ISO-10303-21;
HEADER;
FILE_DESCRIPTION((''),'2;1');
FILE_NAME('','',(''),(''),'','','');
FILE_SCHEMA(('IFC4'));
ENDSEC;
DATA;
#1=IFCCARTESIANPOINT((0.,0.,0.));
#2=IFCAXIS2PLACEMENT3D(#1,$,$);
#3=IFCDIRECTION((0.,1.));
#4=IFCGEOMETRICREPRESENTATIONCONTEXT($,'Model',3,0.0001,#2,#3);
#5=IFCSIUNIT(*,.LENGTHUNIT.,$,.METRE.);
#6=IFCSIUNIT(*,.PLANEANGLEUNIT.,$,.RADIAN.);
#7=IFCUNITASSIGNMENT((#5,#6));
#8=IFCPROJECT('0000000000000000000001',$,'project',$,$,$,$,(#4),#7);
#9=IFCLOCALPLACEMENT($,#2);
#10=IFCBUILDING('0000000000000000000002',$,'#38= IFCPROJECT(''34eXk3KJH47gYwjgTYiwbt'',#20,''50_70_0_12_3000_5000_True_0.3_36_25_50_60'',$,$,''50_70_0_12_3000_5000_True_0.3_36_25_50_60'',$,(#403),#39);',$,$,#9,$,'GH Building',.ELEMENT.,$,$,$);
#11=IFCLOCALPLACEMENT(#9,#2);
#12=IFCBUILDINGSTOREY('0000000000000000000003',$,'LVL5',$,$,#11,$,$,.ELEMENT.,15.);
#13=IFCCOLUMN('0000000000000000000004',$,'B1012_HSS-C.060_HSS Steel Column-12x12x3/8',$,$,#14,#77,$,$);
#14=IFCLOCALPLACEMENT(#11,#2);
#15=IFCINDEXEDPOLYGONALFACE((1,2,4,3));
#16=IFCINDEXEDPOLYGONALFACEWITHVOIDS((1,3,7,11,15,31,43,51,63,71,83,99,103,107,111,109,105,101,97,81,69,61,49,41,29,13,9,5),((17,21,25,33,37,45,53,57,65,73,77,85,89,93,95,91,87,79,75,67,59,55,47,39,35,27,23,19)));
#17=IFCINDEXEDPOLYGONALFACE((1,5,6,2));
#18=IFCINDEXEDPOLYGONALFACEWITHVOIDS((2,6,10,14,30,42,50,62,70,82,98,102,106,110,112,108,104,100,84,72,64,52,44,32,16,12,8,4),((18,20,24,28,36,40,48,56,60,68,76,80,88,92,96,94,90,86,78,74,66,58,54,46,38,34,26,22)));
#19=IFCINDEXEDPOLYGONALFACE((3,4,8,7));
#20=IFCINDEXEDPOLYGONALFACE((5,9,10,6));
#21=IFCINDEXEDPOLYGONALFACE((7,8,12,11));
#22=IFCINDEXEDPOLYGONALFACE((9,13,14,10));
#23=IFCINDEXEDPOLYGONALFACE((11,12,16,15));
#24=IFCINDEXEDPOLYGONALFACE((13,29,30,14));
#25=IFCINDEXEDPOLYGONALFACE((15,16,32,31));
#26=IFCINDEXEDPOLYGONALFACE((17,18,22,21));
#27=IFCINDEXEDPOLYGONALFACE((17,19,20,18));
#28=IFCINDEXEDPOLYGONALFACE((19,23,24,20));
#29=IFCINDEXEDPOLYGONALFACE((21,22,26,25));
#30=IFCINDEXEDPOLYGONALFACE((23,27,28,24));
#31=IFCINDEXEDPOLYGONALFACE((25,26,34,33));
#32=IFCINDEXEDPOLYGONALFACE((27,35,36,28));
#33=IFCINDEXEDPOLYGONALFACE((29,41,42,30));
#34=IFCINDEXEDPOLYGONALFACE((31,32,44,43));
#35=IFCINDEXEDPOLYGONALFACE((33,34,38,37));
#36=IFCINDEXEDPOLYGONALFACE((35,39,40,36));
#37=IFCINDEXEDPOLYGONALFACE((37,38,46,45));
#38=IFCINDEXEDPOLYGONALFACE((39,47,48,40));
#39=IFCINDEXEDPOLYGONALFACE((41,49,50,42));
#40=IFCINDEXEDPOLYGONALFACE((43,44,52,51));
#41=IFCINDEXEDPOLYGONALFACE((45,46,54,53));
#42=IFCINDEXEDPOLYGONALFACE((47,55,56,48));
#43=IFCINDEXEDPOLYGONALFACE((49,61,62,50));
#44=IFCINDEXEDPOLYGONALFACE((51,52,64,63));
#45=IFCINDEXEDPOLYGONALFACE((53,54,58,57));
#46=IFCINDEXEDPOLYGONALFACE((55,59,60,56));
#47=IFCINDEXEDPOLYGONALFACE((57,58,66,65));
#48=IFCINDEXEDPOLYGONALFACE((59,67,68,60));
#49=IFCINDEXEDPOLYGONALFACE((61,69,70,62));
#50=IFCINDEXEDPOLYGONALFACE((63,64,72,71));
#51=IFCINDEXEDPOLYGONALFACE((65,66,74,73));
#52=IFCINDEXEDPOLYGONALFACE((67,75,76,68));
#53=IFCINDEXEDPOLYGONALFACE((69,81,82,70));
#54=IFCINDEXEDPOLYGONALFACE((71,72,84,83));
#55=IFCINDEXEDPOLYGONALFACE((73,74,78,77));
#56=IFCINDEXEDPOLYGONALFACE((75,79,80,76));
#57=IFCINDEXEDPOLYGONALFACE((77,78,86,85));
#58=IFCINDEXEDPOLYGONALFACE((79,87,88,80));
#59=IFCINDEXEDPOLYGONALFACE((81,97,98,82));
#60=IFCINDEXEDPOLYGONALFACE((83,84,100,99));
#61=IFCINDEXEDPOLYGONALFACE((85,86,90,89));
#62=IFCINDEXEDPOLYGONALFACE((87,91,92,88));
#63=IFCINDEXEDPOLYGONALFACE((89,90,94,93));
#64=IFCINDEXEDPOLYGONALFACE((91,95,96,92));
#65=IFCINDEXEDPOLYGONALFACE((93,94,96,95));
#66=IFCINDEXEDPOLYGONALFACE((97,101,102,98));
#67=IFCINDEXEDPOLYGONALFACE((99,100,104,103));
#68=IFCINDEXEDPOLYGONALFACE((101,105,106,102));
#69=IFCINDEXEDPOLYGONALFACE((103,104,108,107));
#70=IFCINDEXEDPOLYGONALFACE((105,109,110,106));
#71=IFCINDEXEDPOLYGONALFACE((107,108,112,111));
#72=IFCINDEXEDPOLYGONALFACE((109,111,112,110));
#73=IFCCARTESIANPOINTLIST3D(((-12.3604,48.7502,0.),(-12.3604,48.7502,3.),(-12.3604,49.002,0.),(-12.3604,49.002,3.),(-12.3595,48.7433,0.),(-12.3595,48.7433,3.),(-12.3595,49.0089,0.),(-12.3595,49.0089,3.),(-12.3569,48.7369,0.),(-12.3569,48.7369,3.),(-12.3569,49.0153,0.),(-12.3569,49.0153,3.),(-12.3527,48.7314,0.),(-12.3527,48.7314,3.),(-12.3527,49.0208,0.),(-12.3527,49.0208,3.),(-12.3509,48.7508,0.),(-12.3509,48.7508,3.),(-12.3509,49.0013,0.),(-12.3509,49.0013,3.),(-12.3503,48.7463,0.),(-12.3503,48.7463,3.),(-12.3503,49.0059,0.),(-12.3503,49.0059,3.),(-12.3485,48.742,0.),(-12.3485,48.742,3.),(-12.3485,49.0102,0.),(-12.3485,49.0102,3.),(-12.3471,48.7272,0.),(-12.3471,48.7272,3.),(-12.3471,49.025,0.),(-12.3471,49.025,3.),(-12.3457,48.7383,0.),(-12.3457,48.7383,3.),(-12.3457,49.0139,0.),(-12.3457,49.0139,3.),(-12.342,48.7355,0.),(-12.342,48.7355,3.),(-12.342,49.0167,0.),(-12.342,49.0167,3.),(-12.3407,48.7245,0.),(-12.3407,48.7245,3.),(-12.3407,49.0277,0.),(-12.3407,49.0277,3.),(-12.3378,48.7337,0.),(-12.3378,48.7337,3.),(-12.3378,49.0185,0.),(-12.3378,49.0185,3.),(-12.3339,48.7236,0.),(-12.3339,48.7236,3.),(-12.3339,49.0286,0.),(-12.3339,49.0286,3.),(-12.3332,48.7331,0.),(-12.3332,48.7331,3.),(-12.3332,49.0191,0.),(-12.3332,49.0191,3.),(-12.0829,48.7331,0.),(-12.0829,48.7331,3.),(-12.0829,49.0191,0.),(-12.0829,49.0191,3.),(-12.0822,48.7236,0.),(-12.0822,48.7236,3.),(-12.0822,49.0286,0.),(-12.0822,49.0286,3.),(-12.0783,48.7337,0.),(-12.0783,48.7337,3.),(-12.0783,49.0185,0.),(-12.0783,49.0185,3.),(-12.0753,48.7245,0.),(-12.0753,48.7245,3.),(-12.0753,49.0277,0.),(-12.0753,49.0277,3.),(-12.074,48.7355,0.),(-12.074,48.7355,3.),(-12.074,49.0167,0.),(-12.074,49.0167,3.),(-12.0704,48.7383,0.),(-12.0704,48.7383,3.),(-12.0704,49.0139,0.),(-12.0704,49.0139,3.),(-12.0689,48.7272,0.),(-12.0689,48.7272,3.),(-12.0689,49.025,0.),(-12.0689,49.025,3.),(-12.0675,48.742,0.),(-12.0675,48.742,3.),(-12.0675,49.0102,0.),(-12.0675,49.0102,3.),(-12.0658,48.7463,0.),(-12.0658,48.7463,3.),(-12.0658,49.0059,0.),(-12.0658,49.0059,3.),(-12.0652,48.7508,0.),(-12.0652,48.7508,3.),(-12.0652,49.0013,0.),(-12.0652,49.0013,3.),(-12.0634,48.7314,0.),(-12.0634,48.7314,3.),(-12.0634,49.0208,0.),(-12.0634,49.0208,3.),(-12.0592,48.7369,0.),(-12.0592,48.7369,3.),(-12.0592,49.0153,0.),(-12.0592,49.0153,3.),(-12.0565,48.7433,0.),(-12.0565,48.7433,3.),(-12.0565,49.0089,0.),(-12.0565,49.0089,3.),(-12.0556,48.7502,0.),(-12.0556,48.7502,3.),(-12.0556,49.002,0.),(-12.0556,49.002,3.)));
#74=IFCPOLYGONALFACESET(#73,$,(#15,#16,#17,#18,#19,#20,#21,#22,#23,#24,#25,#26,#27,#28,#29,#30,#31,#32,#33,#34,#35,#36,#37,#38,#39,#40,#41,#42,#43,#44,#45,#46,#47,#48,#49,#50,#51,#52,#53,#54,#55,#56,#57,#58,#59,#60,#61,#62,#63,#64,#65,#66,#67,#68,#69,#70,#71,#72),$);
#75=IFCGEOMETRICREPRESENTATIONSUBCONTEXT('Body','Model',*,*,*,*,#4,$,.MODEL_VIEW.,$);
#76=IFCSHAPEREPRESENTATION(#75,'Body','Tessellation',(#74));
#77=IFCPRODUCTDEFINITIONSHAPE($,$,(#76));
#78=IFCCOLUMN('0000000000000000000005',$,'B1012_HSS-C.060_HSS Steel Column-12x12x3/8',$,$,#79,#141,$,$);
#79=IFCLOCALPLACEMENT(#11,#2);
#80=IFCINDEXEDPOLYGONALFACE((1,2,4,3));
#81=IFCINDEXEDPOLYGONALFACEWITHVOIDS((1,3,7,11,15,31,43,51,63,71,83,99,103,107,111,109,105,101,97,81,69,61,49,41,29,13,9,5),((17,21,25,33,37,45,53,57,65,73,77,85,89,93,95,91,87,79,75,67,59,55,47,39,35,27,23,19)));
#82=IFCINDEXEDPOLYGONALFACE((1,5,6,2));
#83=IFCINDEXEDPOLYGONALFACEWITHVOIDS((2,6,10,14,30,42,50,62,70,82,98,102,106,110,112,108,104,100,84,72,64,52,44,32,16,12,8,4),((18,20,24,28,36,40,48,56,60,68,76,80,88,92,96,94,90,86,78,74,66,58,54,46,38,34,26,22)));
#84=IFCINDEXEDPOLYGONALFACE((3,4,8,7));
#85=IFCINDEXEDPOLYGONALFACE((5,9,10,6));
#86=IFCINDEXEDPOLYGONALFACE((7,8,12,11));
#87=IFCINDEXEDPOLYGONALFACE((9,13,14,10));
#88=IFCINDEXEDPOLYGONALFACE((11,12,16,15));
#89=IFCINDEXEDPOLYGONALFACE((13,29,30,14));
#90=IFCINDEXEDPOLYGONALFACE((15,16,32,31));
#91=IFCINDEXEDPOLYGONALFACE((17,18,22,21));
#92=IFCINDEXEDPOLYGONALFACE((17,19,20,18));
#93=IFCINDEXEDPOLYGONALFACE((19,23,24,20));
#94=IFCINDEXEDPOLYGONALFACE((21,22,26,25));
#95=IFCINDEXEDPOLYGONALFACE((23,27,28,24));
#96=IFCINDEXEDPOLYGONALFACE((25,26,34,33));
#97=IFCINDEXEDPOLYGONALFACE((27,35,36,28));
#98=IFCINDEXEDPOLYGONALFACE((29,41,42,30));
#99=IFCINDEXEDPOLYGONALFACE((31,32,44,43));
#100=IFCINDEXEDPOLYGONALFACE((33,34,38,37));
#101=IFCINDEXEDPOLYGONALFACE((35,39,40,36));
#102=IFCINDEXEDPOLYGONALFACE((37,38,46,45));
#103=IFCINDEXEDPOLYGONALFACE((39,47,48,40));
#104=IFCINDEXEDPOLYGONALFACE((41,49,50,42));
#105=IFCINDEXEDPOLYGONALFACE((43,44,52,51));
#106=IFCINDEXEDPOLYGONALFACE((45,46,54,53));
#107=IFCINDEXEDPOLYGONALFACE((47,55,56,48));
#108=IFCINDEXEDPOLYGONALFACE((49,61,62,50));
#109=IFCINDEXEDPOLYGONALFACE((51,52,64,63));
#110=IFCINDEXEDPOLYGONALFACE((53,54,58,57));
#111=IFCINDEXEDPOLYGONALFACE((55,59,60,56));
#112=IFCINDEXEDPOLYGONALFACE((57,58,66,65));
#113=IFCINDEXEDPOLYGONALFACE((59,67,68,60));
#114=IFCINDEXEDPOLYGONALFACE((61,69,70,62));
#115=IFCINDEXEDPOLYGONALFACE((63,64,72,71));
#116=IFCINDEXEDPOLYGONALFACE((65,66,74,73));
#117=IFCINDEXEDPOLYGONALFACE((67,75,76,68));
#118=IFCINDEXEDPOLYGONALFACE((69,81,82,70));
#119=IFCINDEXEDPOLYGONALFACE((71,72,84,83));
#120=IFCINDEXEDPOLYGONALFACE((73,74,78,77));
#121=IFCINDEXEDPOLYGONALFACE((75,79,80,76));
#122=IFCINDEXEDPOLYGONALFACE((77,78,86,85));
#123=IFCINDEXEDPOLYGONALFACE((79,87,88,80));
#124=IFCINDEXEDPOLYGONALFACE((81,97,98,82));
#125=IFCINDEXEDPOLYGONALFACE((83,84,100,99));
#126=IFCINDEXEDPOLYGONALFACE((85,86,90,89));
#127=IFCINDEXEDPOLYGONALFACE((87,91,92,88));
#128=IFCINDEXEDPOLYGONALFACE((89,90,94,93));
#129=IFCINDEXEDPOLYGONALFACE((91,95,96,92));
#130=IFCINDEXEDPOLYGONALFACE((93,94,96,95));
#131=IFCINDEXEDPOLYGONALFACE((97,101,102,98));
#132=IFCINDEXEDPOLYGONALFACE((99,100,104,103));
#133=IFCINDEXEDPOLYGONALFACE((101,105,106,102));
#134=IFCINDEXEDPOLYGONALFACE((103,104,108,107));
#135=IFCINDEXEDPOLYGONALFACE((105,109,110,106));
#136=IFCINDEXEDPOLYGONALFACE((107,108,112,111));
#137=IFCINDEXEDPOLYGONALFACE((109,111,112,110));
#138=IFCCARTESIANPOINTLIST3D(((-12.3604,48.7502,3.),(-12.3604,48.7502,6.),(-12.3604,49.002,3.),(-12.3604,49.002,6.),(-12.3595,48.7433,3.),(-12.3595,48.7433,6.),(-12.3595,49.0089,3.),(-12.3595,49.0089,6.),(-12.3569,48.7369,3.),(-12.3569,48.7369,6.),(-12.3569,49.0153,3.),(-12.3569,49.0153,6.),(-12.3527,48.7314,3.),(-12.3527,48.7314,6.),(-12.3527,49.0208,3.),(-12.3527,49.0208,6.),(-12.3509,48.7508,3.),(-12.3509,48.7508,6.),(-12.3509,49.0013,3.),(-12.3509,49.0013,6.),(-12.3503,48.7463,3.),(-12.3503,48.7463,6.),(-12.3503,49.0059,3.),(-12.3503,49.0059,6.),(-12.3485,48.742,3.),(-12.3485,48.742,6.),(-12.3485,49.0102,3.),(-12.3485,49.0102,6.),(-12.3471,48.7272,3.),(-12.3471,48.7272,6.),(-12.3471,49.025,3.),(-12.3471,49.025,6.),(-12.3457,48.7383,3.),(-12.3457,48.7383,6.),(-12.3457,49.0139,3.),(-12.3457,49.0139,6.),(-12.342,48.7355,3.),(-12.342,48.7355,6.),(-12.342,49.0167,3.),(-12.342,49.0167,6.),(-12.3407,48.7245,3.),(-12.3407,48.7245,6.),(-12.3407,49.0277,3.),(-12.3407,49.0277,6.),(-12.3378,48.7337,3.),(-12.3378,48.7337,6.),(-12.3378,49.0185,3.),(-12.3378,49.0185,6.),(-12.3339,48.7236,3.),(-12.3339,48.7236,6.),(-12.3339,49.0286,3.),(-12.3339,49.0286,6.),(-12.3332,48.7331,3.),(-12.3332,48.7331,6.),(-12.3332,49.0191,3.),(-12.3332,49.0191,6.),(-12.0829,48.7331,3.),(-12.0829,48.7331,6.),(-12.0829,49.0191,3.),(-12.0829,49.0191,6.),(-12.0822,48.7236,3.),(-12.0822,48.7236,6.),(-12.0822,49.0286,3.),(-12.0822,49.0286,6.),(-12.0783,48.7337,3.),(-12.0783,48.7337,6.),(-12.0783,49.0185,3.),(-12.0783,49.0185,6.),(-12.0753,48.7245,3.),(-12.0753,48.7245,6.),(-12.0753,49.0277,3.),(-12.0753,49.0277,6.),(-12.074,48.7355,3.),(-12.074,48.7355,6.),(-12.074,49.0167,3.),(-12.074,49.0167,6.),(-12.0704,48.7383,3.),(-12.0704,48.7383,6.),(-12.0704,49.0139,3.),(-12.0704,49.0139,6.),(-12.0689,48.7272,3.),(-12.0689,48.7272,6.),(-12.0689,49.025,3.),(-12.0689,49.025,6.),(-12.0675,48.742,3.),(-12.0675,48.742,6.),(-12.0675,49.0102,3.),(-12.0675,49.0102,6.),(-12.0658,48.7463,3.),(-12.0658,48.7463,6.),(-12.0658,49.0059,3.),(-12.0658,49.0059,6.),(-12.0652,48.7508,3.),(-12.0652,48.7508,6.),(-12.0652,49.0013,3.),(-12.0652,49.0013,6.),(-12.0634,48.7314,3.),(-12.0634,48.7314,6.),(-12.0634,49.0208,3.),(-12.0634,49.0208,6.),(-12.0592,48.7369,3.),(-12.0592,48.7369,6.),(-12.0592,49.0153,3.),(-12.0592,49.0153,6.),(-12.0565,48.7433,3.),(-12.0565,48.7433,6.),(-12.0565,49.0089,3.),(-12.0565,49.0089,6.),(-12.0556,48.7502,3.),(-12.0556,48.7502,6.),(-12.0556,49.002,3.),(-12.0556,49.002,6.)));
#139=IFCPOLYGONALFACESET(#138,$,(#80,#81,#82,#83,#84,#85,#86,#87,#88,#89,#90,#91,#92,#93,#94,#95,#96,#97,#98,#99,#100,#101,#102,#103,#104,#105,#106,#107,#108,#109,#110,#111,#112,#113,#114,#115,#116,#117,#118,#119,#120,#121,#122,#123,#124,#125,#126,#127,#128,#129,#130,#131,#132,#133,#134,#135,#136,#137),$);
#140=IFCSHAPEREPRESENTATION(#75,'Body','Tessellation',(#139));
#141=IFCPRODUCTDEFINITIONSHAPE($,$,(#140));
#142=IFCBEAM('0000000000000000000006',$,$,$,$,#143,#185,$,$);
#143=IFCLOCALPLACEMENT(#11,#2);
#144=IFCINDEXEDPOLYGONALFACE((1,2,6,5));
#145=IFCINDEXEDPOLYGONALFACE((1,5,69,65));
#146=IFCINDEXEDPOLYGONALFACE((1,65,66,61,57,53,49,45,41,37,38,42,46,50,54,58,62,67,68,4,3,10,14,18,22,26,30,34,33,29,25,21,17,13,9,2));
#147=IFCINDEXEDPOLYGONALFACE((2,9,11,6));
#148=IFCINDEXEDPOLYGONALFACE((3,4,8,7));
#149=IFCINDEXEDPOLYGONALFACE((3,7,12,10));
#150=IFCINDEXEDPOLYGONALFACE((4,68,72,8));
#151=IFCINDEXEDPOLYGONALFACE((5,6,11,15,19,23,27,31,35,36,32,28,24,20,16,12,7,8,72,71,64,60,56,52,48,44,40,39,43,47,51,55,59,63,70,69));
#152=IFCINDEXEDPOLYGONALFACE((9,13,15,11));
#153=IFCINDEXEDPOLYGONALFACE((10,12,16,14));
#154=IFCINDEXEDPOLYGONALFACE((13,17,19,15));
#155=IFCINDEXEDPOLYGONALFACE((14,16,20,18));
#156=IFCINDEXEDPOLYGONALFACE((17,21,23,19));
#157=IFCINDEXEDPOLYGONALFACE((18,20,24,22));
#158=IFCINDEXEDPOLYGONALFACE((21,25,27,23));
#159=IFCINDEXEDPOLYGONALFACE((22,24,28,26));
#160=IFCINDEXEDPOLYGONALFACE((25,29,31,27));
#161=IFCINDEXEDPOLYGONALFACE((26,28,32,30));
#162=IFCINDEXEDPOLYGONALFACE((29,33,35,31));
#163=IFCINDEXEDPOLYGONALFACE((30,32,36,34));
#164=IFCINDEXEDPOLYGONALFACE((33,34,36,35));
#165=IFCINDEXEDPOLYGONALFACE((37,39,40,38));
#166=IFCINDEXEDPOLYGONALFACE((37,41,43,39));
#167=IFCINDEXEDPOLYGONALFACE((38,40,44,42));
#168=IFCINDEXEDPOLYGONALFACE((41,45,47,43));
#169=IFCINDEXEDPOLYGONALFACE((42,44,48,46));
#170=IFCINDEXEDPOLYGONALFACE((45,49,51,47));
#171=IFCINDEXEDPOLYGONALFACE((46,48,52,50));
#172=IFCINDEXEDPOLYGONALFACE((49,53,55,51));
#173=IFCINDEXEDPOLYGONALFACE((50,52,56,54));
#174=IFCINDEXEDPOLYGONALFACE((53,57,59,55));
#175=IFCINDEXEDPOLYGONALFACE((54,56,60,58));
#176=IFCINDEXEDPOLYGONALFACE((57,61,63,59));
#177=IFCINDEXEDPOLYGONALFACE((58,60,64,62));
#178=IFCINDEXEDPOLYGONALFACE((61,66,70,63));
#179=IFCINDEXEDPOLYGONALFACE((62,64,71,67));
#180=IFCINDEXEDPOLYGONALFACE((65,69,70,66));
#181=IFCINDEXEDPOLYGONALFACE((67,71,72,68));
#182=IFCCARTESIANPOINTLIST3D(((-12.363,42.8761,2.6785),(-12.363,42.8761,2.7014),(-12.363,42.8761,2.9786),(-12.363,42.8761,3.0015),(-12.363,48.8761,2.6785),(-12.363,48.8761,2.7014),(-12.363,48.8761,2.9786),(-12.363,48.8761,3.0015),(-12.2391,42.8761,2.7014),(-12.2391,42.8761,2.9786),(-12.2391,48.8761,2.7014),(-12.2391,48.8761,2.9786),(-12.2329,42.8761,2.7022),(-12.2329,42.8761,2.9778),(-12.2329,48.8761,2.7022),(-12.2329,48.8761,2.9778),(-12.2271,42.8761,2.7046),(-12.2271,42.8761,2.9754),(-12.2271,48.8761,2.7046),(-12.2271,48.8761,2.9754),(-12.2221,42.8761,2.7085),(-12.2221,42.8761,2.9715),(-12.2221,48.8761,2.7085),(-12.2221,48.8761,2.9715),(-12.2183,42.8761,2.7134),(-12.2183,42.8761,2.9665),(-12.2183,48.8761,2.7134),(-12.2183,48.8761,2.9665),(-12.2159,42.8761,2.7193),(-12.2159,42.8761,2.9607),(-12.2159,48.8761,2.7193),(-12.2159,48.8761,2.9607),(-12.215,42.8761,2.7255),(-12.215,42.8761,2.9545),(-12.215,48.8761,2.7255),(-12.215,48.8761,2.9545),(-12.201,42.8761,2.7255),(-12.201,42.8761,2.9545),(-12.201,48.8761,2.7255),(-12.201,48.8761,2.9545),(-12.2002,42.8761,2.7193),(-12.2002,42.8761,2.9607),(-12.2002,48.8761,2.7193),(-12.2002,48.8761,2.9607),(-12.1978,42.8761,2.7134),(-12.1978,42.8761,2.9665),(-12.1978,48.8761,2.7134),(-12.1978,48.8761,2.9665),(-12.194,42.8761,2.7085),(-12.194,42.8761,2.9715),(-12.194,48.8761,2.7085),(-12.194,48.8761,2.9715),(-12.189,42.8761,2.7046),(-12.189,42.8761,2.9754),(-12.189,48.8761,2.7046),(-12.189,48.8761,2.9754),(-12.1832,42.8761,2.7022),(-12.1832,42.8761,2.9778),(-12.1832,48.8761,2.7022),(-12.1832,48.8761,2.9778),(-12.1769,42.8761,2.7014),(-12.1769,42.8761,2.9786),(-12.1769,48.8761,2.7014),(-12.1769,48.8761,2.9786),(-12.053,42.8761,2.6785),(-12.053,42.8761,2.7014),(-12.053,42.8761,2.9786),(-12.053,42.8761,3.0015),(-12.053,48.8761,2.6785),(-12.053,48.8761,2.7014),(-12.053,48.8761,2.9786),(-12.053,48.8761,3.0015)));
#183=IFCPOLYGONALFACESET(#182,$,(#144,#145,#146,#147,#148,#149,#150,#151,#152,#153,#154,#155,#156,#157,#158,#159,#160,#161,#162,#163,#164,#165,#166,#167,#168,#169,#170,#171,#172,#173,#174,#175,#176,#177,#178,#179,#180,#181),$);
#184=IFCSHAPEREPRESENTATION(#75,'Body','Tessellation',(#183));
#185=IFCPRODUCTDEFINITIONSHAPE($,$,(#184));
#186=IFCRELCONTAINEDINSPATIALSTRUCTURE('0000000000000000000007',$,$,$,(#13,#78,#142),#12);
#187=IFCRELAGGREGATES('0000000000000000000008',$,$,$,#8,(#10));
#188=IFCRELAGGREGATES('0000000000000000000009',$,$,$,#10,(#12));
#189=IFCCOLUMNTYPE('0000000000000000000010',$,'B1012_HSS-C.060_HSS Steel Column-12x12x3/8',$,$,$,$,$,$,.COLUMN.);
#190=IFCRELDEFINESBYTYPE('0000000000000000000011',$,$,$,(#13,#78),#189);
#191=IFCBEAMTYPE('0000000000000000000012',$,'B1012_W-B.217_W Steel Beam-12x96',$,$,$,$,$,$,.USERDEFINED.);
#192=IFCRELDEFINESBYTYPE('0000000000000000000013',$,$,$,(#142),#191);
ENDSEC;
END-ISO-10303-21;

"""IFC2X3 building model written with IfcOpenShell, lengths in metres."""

from ifc_helpers import new_model, si_unit, direction, frame, origin, origin_2d, place, context, subcontext, project, spatial, hollow_rectangle, i_section, extrude, type_object, element, save


model = new_model("IFC2X3")

# Units and contexts
model_context = context("Model", 3, precision=0.0001, world=origin(), true_north=direction((0.0, 1.0)))
body_context = subcontext(model_context, "Body", "Model", "MODEL_VIEW")
ifc_project = project(units=[si_unit("LENGTHUNIT", "METRE"), si_unit("PLANEANGLEUNIT", "RADIAN")], contexts=[model_context])

# Building, storey
building_placement = place(None, origin())
building = spatial("IfcBuilding", under=ifc_project, at=building_placement, Name="#38= IFCPROJECT('34eXk3KJH47gYwjgTYiwbt',#20,'50_70_0_12_3000_5000_True_0.3_36_25_50_60',$,$,'50_70_0_12_3000_5000_True_0.3_36_25_50_60',$,(#403),#39);", LongName="GH Building", CompositionType="ELEMENT")
storey_placement = place(building_placement, origin())
storey = spatial("IfcBuildingStorey", under=building, at=storey_placement, Name="LVL5", CompositionType="ELEMENT", Elevation=15.0)

# Columns
column_type = type_object("IfcColumnType", Name="B1012_HSS-C.060_HSS Steel Column-12x12x3/8", PredefinedType="COLUMN")
for number, where, z_axis, x_axis, name in (
    (1, (-12.208, 48.8761, 3.0), (0.0, 0.0, -1.0), (-1.0, 0.0, 0.0), "B1012_HSS-C.060_HSS Steel Column-12x12x3/8"),
    (2, (-12.208, 48.8761, 6.0), (0.0, 0.0, -1.0), (-1.0, 0.0, 0.0), "B1012_HSS-C.060_HSS Steel Column-12x12x3/8"),
):
    element("IfcColumn", number, at=place(storey_placement, frame(where, z_axis=z_axis, x_axis=x_axis)), inside=storey, type_object=column_type, Name=name, context=body_context, shape_type="SweptSolid", body=[
        extrude(hollow_rectangle(XDim=0.3048, YDim=0.305, WallThickness=0.0095, InnerFilletRadius=0.0177, OuterFilletRadius=0.0266, at=origin_2d()), origin(), (0.0, 0.0, 1.0), 3.0),
    ])

# Beam
beam_type = type_object("IfcBeamType", Name="B1012_W-B.217_W Steel Beam-12x96", PredefinedType="USERDEFINED")
for number, where, z_axis, x_axis in (
    (3, (-12.208, 42.8761, 2.84), (0.0, 1.0, 0.0), (-1.0, 0.0, 0.0)),
):
    element("IfcBeam", number, at=place(storey_placement, frame(where, z_axis=z_axis, x_axis=x_axis)), inside=storey, type_object=beam_type, context=body_context, shape_type="SweptSolid", body=[
        extrude(i_section(OverallWidth=0.31, OverallDepth=0.323, WebThickness=0.014, FlangeThickness=0.0229, FilletRadius=0.0241, at=origin_2d()), origin(), (0.0, 0.0, 1.0), 6.0),
    ])

save(model, "model.ifc")
